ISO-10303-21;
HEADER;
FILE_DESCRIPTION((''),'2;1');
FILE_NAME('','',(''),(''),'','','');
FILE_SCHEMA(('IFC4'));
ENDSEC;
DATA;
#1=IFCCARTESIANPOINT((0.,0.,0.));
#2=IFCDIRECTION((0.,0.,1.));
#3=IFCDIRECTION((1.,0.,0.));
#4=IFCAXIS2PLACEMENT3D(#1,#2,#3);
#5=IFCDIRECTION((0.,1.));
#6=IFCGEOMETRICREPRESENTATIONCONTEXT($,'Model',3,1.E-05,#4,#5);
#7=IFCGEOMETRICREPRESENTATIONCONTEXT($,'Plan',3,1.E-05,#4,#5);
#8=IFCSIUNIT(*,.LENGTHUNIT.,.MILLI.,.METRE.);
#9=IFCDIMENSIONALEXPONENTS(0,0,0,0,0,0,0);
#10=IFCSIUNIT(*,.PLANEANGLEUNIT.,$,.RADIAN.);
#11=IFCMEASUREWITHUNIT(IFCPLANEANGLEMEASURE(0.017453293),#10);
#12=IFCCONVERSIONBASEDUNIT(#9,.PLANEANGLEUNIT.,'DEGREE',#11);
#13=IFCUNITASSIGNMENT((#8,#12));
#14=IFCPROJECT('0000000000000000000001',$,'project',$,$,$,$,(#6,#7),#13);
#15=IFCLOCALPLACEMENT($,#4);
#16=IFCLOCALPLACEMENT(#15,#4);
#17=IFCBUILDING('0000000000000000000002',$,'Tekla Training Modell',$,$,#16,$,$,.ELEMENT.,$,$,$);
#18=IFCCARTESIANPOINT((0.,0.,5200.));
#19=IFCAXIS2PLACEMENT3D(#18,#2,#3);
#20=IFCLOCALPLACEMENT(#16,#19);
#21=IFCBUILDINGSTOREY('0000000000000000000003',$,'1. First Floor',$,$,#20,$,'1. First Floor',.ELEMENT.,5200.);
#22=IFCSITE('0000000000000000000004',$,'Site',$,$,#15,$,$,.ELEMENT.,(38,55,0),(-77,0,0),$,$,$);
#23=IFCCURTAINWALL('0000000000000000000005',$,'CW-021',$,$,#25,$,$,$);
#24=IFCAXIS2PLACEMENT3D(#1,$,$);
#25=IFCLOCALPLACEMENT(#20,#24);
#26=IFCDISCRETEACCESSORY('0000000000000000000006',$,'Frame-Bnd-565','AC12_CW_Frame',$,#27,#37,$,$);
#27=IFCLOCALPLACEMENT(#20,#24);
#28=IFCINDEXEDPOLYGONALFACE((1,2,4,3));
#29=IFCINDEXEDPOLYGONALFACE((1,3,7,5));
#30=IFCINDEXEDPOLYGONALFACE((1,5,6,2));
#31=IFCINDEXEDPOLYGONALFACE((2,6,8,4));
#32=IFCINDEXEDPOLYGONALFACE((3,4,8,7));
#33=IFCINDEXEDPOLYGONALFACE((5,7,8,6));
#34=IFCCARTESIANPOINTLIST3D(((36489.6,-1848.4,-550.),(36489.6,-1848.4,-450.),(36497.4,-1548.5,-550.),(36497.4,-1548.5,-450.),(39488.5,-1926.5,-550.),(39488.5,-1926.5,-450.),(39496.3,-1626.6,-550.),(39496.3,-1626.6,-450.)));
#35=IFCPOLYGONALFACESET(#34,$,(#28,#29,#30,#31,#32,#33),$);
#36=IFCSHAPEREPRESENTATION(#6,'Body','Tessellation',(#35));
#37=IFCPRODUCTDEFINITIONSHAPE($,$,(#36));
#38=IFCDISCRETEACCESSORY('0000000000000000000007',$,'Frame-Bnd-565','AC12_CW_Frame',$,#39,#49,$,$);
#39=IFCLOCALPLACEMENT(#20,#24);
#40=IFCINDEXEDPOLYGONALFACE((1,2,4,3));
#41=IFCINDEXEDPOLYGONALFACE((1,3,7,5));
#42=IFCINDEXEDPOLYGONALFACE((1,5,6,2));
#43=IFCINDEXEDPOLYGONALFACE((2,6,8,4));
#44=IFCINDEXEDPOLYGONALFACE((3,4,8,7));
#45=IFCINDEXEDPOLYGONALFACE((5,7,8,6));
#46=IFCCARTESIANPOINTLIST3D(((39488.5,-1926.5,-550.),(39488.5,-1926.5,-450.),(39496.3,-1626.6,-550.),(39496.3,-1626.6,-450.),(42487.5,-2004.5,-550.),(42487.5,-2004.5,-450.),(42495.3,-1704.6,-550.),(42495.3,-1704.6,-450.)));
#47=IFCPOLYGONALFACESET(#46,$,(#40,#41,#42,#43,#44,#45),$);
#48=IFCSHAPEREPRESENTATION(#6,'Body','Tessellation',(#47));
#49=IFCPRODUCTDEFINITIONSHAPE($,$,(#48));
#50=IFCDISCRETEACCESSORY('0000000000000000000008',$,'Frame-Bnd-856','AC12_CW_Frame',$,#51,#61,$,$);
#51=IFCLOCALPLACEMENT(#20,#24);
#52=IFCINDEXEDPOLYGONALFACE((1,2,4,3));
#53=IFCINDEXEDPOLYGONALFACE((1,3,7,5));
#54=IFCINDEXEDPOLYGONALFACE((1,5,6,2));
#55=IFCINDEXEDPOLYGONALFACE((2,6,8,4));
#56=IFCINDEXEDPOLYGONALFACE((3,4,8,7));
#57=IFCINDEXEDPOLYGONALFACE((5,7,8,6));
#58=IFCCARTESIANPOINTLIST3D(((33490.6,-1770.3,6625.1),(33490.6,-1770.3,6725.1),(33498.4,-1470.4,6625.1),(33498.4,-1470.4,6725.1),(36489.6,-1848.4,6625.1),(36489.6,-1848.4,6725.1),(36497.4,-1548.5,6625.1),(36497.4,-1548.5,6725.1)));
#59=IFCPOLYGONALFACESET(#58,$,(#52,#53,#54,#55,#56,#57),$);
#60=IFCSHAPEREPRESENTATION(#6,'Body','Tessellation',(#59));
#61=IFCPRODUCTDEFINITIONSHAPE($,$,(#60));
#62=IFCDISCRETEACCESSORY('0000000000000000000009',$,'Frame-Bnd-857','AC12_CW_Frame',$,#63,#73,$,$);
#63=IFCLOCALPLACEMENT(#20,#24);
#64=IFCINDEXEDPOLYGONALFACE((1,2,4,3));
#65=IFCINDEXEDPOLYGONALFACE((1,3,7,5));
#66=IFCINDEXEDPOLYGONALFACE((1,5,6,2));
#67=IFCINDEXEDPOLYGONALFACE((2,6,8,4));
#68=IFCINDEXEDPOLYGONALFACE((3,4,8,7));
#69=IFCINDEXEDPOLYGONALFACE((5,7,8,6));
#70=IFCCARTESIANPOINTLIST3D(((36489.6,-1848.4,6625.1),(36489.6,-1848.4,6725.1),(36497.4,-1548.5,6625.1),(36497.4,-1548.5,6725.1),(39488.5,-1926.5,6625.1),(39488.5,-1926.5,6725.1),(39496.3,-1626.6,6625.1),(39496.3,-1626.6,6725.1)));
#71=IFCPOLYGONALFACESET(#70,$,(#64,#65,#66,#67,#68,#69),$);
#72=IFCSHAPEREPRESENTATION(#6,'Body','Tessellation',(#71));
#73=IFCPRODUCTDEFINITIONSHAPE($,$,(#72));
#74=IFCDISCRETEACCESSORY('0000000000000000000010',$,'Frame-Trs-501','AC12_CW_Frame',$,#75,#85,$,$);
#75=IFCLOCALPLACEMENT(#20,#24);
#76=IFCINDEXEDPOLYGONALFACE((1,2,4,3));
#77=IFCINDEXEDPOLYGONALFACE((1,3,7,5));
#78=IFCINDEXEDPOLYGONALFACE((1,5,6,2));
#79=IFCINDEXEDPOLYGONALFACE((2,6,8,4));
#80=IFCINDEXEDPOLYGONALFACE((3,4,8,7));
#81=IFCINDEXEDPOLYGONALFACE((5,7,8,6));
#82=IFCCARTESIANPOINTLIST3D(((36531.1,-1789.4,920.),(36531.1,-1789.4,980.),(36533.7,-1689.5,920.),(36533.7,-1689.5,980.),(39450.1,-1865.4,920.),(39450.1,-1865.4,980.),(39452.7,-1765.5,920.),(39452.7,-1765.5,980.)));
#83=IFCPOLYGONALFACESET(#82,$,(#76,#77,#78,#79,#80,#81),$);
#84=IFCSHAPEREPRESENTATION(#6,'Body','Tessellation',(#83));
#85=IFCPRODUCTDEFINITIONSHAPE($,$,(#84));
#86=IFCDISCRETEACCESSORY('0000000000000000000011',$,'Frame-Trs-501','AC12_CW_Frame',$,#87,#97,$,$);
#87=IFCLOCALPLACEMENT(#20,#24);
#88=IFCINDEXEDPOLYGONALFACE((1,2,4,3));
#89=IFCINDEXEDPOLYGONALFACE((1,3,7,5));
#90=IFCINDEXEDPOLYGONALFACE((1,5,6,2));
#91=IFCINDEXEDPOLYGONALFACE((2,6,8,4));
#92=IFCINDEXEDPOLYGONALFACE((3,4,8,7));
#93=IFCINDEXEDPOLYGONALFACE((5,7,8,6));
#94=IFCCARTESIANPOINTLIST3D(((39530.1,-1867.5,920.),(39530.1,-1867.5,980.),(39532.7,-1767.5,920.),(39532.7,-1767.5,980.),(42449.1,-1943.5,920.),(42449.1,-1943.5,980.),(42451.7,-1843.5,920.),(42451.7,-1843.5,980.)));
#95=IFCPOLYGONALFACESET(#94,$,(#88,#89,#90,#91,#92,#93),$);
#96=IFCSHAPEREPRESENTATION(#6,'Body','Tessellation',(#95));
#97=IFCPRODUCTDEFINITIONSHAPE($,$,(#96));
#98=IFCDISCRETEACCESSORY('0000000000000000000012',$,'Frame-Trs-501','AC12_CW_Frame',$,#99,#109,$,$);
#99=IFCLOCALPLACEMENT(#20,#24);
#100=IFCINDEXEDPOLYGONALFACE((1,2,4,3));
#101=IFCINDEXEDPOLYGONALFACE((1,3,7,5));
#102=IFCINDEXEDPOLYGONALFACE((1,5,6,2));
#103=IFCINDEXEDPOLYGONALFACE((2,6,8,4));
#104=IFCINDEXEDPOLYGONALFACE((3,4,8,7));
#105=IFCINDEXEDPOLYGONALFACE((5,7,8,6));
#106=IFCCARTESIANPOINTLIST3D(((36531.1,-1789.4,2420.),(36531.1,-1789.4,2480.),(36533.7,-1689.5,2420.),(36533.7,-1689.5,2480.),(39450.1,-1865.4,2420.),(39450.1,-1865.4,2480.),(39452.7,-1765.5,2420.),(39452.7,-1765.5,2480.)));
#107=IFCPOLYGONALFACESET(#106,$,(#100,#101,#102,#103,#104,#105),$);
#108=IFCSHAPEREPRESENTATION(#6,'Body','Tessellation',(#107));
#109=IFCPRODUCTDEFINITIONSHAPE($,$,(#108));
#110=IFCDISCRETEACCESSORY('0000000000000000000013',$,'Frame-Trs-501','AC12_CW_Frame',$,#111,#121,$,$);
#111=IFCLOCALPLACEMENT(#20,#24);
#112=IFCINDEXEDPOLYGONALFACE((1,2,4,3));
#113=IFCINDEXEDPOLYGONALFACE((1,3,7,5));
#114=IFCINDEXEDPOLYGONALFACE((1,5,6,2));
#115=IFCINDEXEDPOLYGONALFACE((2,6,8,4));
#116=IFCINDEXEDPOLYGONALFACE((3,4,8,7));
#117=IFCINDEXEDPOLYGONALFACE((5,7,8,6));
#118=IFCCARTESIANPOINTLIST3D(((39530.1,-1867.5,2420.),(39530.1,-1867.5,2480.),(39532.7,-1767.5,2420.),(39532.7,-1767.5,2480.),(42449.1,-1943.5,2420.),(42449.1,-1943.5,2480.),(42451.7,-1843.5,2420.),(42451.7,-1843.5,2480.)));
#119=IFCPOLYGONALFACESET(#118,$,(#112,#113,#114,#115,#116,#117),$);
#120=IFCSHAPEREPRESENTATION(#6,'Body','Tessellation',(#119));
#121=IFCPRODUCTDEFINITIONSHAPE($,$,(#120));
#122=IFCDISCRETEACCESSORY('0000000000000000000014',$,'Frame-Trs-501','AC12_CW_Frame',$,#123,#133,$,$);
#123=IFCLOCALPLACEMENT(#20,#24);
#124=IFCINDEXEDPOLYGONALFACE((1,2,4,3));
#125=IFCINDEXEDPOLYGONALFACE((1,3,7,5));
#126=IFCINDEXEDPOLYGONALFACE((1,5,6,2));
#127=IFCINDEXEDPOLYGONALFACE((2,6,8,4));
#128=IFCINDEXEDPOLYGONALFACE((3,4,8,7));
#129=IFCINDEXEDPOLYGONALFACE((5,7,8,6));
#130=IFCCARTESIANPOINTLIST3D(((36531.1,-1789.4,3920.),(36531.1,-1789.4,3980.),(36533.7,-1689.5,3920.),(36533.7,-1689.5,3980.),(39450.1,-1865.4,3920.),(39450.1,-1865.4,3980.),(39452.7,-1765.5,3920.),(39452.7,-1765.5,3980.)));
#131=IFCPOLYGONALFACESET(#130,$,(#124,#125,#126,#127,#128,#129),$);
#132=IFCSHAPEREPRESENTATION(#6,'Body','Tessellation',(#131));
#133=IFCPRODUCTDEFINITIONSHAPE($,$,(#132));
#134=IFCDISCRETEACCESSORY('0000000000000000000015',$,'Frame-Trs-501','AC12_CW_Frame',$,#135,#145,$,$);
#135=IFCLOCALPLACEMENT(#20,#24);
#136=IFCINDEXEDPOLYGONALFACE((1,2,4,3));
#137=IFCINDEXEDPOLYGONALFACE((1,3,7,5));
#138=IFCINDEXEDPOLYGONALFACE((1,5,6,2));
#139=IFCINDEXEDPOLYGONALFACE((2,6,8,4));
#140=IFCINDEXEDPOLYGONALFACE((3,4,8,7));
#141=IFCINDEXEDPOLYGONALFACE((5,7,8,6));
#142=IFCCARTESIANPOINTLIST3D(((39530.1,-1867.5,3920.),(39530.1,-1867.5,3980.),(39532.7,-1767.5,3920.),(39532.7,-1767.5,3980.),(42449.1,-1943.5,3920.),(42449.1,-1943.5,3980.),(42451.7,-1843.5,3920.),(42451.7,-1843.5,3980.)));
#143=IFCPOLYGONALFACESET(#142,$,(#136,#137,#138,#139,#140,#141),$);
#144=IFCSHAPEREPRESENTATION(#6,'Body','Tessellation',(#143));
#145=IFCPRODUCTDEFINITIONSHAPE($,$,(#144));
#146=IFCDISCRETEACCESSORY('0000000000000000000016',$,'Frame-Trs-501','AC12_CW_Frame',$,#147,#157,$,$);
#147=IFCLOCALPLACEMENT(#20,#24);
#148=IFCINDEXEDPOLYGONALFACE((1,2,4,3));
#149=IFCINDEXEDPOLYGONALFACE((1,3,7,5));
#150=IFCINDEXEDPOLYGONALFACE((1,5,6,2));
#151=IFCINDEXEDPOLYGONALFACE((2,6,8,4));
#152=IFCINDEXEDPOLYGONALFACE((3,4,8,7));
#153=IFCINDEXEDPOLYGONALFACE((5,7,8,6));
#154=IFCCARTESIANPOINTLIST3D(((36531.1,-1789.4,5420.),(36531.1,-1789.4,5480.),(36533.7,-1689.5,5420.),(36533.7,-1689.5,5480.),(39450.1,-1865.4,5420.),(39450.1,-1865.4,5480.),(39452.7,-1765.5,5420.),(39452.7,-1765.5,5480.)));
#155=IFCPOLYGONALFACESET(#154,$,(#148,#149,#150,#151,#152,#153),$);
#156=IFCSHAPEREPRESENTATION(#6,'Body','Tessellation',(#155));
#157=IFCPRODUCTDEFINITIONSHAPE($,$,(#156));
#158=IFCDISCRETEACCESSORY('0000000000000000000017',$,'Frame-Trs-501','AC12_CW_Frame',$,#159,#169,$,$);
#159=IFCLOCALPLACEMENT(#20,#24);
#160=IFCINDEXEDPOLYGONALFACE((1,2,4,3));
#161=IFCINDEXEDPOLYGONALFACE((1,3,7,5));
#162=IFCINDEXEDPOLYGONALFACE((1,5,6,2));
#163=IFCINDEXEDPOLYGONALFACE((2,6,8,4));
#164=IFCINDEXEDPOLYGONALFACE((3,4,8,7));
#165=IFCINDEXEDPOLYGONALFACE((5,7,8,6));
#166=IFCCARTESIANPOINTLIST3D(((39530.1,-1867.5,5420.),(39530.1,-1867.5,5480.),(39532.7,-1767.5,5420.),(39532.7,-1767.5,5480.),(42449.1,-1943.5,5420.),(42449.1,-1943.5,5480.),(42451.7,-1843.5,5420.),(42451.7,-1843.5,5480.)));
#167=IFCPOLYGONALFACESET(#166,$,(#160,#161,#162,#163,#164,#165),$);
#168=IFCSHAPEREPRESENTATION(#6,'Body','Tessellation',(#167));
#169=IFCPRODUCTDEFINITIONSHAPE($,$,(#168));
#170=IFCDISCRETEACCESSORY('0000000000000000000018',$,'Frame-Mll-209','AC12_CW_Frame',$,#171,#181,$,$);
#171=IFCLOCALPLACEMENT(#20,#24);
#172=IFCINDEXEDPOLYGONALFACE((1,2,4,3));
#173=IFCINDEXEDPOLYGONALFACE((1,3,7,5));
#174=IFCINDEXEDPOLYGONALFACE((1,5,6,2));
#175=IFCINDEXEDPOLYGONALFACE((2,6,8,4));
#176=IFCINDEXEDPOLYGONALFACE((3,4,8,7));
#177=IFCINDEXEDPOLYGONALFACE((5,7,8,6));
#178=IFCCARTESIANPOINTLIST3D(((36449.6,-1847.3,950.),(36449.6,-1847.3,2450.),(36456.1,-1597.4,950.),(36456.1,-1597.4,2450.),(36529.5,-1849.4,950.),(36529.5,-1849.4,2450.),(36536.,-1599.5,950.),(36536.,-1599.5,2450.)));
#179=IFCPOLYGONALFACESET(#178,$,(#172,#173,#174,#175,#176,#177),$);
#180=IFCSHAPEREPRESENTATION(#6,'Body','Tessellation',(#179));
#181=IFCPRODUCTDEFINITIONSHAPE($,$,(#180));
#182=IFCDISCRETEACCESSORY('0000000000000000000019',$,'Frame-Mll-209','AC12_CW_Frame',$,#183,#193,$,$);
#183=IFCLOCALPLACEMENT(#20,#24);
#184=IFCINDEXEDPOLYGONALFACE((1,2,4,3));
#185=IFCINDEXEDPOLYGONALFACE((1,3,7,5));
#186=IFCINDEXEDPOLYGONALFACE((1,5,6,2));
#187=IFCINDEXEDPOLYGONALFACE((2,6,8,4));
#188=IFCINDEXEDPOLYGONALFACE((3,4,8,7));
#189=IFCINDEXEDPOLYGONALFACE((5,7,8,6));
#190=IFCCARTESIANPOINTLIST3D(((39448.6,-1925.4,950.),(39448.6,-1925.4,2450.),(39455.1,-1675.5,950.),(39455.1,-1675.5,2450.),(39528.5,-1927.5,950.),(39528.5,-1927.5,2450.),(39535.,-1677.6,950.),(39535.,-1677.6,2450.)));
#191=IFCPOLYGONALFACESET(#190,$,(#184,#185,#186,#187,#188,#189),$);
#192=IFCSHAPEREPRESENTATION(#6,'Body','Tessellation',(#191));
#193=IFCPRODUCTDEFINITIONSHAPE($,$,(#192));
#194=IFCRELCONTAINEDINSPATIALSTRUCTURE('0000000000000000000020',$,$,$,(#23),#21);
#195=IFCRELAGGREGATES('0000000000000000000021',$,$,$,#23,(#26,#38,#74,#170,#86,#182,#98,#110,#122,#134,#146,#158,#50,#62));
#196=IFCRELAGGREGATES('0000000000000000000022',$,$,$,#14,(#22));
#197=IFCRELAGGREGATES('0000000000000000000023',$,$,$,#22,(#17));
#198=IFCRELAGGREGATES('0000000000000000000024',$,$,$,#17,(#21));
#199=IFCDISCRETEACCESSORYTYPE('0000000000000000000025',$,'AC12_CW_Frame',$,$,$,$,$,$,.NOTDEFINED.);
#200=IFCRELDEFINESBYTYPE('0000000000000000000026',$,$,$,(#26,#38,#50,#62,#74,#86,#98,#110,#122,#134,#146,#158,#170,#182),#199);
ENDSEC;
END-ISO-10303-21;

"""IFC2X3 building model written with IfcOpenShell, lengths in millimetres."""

from ifc_helpers import new_model, entity, si_unit, converted_unit, direction, frame, origin_with_axes, place, context, project, spatial, polyline, outline, extrude, source, transform, mapped, type_object, element, aggregate, save


model = new_model("IFC2X3")

# Units and contexts
model_context = context("Model", 3, precision=1e-05, world=origin_with_axes(), true_north=direction((0.0, 1.0)))
plan_context = context("Plan", 3, precision=1e-05, world=origin_with_axes(), true_north=direction((0.0, 1.0)))
ifc_project = project(units=[si_unit("LENGTHUNIT", "METRE", prefix="MILLI"), converted_unit("PLANEANGLEUNIT", "DEGREE", entity("IfcPlaneAngleMeasure", 0.017453293), si_unit("PLANEANGLEUNIT", "RADIAN"), dimensions=[0, 0, 0, 0, 0, 0, 0])], contexts=[model_context, plan_context])

# Site, building, storey
site_placement = place(None, origin_with_axes())
site = spatial("IfcSite", under=ifc_project, at=site_placement, Name="Site", CompositionType="ELEMENT", RefLatitude=(38, 55, 0), RefLongitude=(-77, 0, 0))
building_placement = place(site_placement, origin_with_axes())
building = spatial("IfcBuilding", under=site, at=building_placement, Name="Tekla Training Modell", CompositionType="ELEMENT")
storey_placement = place(building_placement, frame((0.0, 0.0, 5200.0), z_axis=(0.0, 0.0, 1.0), x_axis=(1.0, 0.0, 0.0)))
storey = spatial("IfcBuildingStorey", under=building, at=storey_placement, Name="1. First Floor", LongName="1. First Floor", CompositionType="ELEMENT", Elevation=5200.0)

# Curtain wall, discrete accessories
curtain_wall_placement = place(storey_placement, frame((9500.0, -1095.8, -550.0), z_axis=(0.0, 0.0, 1.0), x_axis=(0.999661, -0.026022, 0.0)))
curtain_wall = element("IfcCurtainWall", 1, at=curtain_wall_placement, inside=storey, Name="CW-021")
discrete_accessory_type = type_object("IfcDiscreteAccessoryType", Name="AC12_CW_Frame")
shared_shape_1 = source(origin_with_axes(), model_context, "Body", "SweptSolid", [
    extrude(outline(polyline([(0.0, 0.0), (300.0, 0.0), (300.0, -3000.0), (0.0, -3000.0), (0.0, 0.0)])), origin_with_axes(), (0.0, 0.0, 1.0), 100.0),
])
discrete_accessory_1_placement = place(storey_placement, frame((36497.4, -1548.5, -450.0), z_axis=(0.0, 0.0, -1.0), x_axis=(-0.026022, -0.999661, 0.0)))
discrete_accessory_1 = element("IfcDiscreteAccessory", 2, at=discrete_accessory_1_placement, type_object=discrete_accessory_type, Name="Frame-Bnd-565", Description="AC12_CW_Frame", context=model_context, shape_type="MappedRepresentation", body=[
    mapped(shared_shape_1, transform((0.0, 0.0, 0.0), scale=1.0)),
])
discrete_accessory_2_placement = place(storey_placement, frame((39496.3, -1626.6, -450.0), z_axis=(0.0, 0.0, -1.0), x_axis=(-0.026022, -0.999661, 0.0)))
discrete_accessory_2 = element("IfcDiscreteAccessory", 3, at=discrete_accessory_2_placement, type_object=discrete_accessory_type, Name="Frame-Bnd-565", Description="AC12_CW_Frame", context=model_context, shape_type="MappedRepresentation", body=[
    mapped(shared_shape_1, transform((0.0, 0.0, 0.0), scale=1.0)),
])
discrete_accessory_3_placement = place(storey_placement, frame((36497.4, -1548.5, 6625.1), z_axis=(0.0, 0.0, 1.0), x_axis=(-0.026022, -0.999661, 0.0)))
discrete_accessory_3 = element("IfcDiscreteAccessory", 4, at=discrete_accessory_3_placement, type_object=discrete_accessory_type, Name="Frame-Bnd-856", Description="AC12_CW_Frame", context=model_context, shape_type="MappedRepresentation", body=[
    mapped(shared_shape_1, transform((0.0, 0.0, 0.0), scale=1.0)),
])
discrete_accessory_4_placement = place(storey_placement, frame((39496.3, -1626.6, 6625.1), z_axis=(0.0, 0.0, 1.0), x_axis=(-0.026022, -0.999661, 0.0)))
discrete_accessory_4 = element("IfcDiscreteAccessory", 5, at=discrete_accessory_4_placement, type_object=discrete_accessory_type, Name="Frame-Bnd-857", Description="AC12_CW_Frame", context=model_context, shape_type="MappedRepresentation", body=[
    mapped(shared_shape_1, transform((0.0, 0.0, 0.0), scale=1.0)),
])
shared_shape_2 = source(origin_with_axes(), model_context, "Body", "SweptSolid", [
    extrude(outline(polyline([(0.0, 0.0), (100.0, 0.0), (100.0, -2920.0), (0.0, -2920.0), (0.0, 0.0)])), origin_with_axes(), (0.0, 0.0, 1.0), 60.0),
])
discrete_accessory_5_placement = place(storey_placement, frame((36533.7, -1689.5, 980.0), z_axis=(0.0, 0.0, -1.0), x_axis=(-0.026022, -0.999661, 0.0)))
discrete_accessory_5 = element("IfcDiscreteAccessory", 6, at=discrete_accessory_5_placement, type_object=discrete_accessory_type, Name="Frame-Trs-501", Description="AC12_CW_Frame", context=model_context, shape_type="MappedRepresentation", body=[
    mapped(shared_shape_2, transform((0.0, 0.0, 0.0), scale=1.0)),
])
discrete_accessory_6_placement = place(storey_placement, frame((39532.7, -1767.5, 980.0), z_axis=(0.0, 0.0, -1.0), x_axis=(-0.026022, -0.999661, 0.0)))
discrete_accessory_6 = element("IfcDiscreteAccessory", 7, at=discrete_accessory_6_placement, type_object=discrete_accessory_type, Name="Frame-Trs-501", Description="AC12_CW_Frame", context=model_context, shape_type="MappedRepresentation", body=[
    mapped(shared_shape_2, transform((0.0, 0.0, 0.0), scale=1.0)),
])
discrete_accessory_7_placement = place(storey_placement, frame((36533.7, -1689.5, 2480.0), z_axis=(0.0, 0.0, -1.0), x_axis=(-0.026022, -0.999661, 0.0)))
discrete_accessory_7 = element("IfcDiscreteAccessory", 8, at=discrete_accessory_7_placement, type_object=discrete_accessory_type, Name="Frame-Trs-501", Description="AC12_CW_Frame", context=model_context, shape_type="MappedRepresentation", body=[
    mapped(shared_shape_2, transform((0.0, 0.0, 0.0), scale=1.0)),
])
discrete_accessory_8_placement = place(storey_placement, frame((39532.7, -1767.5, 2480.0), z_axis=(0.0, 0.0, -1.0), x_axis=(-0.026022, -0.999661, 0.0)))
discrete_accessory_8 = element("IfcDiscreteAccessory", 9, at=discrete_accessory_8_placement, type_object=discrete_accessory_type, Name="Frame-Trs-501", Description="AC12_CW_Frame", context=model_context, shape_type="MappedRepresentation", body=[
    mapped(shared_shape_2, transform((0.0, 0.0, 0.0), scale=1.0)),
])
discrete_accessory_9_placement = place(storey_placement, frame((36533.7, -1689.5, 3980.0), z_axis=(0.0, 0.0, -1.0), x_axis=(-0.026022, -0.999661, 0.0)))
discrete_accessory_9 = element("IfcDiscreteAccessory", 10, at=discrete_accessory_9_placement, type_object=discrete_accessory_type, Name="Frame-Trs-501", Description="AC12_CW_Frame", context=model_context, shape_type="MappedRepresentation", body=[
    mapped(shared_shape_2, transform((0.0, 0.0, 0.0), scale=1.0)),
])
discrete_accessory_10_placement = place(storey_placement, frame((39532.7, -1767.5, 3980.0), z_axis=(0.0, 0.0, -1.0), x_axis=(-0.026022, -0.999661, 0.0)))
discrete_accessory_10 = element("IfcDiscreteAccessory", 11, at=discrete_accessory_10_placement, type_object=discrete_accessory_type, Name="Frame-Trs-501", Description="AC12_CW_Frame", context=model_context, shape_type="MappedRepresentation", body=[
    mapped(shared_shape_2, transform((0.0, 0.0, 0.0), scale=1.0)),
])
discrete_accessory_11_placement = place(storey_placement, frame((36533.7, -1689.5, 5480.0), z_axis=(0.0, 0.0, -1.0), x_axis=(-0.026022, -0.999661, 0.0)))
discrete_accessory_11 = element("IfcDiscreteAccessory", 12, at=discrete_accessory_11_placement, type_object=discrete_accessory_type, Name="Frame-Trs-501", Description="AC12_CW_Frame", context=model_context, shape_type="MappedRepresentation", body=[
    mapped(shared_shape_2, transform((0.0, 0.0, 0.0), scale=1.0)),
])
discrete_accessory_12_placement = place(storey_placement, frame((39532.7, -1767.5, 5480.0), z_axis=(0.0, 0.0, -1.0), x_axis=(-0.026022, -0.999661, 0.0)))
discrete_accessory_12 = element("IfcDiscreteAccessory", 13, at=discrete_accessory_12_placement, type_object=discrete_accessory_type, Name="Frame-Trs-501", Description="AC12_CW_Frame", context=model_context, shape_type="MappedRepresentation", body=[
    mapped(shared_shape_2, transform((0.0, 0.0, 0.0), scale=1.0)),
])
shared_shape_3 = source(origin_with_axes(), model_context, "Body", "SweptSolid", [
    extrude(outline(polyline([(0.0, 0.0), (250.0, 0.0), (250.0, -1500.0), (0.0, -1500.0), (0.0, 0.0)])), origin_with_axes(), (0.0, 0.0, 1.0), 80.0),
])
discrete_accessory_13_placement = place(storey_placement, frame((36456.1, -1597.4, 950.0), z_axis=(0.999661, -0.026022, 0.0), x_axis=(-0.026022, -0.999661, 0.0)))
discrete_accessory_13 = element("IfcDiscreteAccessory", 14, at=discrete_accessory_13_placement, type_object=discrete_accessory_type, Name="Frame-Mll-209", Description="AC12_CW_Frame", context=model_context, shape_type="MappedRepresentation", body=[
    mapped(shared_shape_3, transform((0.0, 0.0, 0.0), scale=1.0)),
])
discrete_accessory_14_placement = place(storey_placement, frame((39455.1, -1675.5, 950.0), z_axis=(0.999661, -0.026022, 0.0), x_axis=(-0.026022, -0.999661, 0.0)))
discrete_accessory_14 = element("IfcDiscreteAccessory", 15, at=discrete_accessory_14_placement, type_object=discrete_accessory_type, Name="Frame-Mll-209", Description="AC12_CW_Frame", context=model_context, shape_type="MappedRepresentation", body=[
    mapped(shared_shape_3, transform((0.0, 0.0, 0.0), scale=1.0)),
])
aggregate(curtain_wall, [discrete_accessory_1, discrete_accessory_2, discrete_accessory_5, discrete_accessory_13, discrete_accessory_6, discrete_accessory_14, discrete_accessory_7, discrete_accessory_8, discrete_accessory_9, discrete_accessory_10, discrete_accessory_11, discrete_accessory_12, discrete_accessory_3, discrete_accessory_4])

save(model, "model.ifc")
